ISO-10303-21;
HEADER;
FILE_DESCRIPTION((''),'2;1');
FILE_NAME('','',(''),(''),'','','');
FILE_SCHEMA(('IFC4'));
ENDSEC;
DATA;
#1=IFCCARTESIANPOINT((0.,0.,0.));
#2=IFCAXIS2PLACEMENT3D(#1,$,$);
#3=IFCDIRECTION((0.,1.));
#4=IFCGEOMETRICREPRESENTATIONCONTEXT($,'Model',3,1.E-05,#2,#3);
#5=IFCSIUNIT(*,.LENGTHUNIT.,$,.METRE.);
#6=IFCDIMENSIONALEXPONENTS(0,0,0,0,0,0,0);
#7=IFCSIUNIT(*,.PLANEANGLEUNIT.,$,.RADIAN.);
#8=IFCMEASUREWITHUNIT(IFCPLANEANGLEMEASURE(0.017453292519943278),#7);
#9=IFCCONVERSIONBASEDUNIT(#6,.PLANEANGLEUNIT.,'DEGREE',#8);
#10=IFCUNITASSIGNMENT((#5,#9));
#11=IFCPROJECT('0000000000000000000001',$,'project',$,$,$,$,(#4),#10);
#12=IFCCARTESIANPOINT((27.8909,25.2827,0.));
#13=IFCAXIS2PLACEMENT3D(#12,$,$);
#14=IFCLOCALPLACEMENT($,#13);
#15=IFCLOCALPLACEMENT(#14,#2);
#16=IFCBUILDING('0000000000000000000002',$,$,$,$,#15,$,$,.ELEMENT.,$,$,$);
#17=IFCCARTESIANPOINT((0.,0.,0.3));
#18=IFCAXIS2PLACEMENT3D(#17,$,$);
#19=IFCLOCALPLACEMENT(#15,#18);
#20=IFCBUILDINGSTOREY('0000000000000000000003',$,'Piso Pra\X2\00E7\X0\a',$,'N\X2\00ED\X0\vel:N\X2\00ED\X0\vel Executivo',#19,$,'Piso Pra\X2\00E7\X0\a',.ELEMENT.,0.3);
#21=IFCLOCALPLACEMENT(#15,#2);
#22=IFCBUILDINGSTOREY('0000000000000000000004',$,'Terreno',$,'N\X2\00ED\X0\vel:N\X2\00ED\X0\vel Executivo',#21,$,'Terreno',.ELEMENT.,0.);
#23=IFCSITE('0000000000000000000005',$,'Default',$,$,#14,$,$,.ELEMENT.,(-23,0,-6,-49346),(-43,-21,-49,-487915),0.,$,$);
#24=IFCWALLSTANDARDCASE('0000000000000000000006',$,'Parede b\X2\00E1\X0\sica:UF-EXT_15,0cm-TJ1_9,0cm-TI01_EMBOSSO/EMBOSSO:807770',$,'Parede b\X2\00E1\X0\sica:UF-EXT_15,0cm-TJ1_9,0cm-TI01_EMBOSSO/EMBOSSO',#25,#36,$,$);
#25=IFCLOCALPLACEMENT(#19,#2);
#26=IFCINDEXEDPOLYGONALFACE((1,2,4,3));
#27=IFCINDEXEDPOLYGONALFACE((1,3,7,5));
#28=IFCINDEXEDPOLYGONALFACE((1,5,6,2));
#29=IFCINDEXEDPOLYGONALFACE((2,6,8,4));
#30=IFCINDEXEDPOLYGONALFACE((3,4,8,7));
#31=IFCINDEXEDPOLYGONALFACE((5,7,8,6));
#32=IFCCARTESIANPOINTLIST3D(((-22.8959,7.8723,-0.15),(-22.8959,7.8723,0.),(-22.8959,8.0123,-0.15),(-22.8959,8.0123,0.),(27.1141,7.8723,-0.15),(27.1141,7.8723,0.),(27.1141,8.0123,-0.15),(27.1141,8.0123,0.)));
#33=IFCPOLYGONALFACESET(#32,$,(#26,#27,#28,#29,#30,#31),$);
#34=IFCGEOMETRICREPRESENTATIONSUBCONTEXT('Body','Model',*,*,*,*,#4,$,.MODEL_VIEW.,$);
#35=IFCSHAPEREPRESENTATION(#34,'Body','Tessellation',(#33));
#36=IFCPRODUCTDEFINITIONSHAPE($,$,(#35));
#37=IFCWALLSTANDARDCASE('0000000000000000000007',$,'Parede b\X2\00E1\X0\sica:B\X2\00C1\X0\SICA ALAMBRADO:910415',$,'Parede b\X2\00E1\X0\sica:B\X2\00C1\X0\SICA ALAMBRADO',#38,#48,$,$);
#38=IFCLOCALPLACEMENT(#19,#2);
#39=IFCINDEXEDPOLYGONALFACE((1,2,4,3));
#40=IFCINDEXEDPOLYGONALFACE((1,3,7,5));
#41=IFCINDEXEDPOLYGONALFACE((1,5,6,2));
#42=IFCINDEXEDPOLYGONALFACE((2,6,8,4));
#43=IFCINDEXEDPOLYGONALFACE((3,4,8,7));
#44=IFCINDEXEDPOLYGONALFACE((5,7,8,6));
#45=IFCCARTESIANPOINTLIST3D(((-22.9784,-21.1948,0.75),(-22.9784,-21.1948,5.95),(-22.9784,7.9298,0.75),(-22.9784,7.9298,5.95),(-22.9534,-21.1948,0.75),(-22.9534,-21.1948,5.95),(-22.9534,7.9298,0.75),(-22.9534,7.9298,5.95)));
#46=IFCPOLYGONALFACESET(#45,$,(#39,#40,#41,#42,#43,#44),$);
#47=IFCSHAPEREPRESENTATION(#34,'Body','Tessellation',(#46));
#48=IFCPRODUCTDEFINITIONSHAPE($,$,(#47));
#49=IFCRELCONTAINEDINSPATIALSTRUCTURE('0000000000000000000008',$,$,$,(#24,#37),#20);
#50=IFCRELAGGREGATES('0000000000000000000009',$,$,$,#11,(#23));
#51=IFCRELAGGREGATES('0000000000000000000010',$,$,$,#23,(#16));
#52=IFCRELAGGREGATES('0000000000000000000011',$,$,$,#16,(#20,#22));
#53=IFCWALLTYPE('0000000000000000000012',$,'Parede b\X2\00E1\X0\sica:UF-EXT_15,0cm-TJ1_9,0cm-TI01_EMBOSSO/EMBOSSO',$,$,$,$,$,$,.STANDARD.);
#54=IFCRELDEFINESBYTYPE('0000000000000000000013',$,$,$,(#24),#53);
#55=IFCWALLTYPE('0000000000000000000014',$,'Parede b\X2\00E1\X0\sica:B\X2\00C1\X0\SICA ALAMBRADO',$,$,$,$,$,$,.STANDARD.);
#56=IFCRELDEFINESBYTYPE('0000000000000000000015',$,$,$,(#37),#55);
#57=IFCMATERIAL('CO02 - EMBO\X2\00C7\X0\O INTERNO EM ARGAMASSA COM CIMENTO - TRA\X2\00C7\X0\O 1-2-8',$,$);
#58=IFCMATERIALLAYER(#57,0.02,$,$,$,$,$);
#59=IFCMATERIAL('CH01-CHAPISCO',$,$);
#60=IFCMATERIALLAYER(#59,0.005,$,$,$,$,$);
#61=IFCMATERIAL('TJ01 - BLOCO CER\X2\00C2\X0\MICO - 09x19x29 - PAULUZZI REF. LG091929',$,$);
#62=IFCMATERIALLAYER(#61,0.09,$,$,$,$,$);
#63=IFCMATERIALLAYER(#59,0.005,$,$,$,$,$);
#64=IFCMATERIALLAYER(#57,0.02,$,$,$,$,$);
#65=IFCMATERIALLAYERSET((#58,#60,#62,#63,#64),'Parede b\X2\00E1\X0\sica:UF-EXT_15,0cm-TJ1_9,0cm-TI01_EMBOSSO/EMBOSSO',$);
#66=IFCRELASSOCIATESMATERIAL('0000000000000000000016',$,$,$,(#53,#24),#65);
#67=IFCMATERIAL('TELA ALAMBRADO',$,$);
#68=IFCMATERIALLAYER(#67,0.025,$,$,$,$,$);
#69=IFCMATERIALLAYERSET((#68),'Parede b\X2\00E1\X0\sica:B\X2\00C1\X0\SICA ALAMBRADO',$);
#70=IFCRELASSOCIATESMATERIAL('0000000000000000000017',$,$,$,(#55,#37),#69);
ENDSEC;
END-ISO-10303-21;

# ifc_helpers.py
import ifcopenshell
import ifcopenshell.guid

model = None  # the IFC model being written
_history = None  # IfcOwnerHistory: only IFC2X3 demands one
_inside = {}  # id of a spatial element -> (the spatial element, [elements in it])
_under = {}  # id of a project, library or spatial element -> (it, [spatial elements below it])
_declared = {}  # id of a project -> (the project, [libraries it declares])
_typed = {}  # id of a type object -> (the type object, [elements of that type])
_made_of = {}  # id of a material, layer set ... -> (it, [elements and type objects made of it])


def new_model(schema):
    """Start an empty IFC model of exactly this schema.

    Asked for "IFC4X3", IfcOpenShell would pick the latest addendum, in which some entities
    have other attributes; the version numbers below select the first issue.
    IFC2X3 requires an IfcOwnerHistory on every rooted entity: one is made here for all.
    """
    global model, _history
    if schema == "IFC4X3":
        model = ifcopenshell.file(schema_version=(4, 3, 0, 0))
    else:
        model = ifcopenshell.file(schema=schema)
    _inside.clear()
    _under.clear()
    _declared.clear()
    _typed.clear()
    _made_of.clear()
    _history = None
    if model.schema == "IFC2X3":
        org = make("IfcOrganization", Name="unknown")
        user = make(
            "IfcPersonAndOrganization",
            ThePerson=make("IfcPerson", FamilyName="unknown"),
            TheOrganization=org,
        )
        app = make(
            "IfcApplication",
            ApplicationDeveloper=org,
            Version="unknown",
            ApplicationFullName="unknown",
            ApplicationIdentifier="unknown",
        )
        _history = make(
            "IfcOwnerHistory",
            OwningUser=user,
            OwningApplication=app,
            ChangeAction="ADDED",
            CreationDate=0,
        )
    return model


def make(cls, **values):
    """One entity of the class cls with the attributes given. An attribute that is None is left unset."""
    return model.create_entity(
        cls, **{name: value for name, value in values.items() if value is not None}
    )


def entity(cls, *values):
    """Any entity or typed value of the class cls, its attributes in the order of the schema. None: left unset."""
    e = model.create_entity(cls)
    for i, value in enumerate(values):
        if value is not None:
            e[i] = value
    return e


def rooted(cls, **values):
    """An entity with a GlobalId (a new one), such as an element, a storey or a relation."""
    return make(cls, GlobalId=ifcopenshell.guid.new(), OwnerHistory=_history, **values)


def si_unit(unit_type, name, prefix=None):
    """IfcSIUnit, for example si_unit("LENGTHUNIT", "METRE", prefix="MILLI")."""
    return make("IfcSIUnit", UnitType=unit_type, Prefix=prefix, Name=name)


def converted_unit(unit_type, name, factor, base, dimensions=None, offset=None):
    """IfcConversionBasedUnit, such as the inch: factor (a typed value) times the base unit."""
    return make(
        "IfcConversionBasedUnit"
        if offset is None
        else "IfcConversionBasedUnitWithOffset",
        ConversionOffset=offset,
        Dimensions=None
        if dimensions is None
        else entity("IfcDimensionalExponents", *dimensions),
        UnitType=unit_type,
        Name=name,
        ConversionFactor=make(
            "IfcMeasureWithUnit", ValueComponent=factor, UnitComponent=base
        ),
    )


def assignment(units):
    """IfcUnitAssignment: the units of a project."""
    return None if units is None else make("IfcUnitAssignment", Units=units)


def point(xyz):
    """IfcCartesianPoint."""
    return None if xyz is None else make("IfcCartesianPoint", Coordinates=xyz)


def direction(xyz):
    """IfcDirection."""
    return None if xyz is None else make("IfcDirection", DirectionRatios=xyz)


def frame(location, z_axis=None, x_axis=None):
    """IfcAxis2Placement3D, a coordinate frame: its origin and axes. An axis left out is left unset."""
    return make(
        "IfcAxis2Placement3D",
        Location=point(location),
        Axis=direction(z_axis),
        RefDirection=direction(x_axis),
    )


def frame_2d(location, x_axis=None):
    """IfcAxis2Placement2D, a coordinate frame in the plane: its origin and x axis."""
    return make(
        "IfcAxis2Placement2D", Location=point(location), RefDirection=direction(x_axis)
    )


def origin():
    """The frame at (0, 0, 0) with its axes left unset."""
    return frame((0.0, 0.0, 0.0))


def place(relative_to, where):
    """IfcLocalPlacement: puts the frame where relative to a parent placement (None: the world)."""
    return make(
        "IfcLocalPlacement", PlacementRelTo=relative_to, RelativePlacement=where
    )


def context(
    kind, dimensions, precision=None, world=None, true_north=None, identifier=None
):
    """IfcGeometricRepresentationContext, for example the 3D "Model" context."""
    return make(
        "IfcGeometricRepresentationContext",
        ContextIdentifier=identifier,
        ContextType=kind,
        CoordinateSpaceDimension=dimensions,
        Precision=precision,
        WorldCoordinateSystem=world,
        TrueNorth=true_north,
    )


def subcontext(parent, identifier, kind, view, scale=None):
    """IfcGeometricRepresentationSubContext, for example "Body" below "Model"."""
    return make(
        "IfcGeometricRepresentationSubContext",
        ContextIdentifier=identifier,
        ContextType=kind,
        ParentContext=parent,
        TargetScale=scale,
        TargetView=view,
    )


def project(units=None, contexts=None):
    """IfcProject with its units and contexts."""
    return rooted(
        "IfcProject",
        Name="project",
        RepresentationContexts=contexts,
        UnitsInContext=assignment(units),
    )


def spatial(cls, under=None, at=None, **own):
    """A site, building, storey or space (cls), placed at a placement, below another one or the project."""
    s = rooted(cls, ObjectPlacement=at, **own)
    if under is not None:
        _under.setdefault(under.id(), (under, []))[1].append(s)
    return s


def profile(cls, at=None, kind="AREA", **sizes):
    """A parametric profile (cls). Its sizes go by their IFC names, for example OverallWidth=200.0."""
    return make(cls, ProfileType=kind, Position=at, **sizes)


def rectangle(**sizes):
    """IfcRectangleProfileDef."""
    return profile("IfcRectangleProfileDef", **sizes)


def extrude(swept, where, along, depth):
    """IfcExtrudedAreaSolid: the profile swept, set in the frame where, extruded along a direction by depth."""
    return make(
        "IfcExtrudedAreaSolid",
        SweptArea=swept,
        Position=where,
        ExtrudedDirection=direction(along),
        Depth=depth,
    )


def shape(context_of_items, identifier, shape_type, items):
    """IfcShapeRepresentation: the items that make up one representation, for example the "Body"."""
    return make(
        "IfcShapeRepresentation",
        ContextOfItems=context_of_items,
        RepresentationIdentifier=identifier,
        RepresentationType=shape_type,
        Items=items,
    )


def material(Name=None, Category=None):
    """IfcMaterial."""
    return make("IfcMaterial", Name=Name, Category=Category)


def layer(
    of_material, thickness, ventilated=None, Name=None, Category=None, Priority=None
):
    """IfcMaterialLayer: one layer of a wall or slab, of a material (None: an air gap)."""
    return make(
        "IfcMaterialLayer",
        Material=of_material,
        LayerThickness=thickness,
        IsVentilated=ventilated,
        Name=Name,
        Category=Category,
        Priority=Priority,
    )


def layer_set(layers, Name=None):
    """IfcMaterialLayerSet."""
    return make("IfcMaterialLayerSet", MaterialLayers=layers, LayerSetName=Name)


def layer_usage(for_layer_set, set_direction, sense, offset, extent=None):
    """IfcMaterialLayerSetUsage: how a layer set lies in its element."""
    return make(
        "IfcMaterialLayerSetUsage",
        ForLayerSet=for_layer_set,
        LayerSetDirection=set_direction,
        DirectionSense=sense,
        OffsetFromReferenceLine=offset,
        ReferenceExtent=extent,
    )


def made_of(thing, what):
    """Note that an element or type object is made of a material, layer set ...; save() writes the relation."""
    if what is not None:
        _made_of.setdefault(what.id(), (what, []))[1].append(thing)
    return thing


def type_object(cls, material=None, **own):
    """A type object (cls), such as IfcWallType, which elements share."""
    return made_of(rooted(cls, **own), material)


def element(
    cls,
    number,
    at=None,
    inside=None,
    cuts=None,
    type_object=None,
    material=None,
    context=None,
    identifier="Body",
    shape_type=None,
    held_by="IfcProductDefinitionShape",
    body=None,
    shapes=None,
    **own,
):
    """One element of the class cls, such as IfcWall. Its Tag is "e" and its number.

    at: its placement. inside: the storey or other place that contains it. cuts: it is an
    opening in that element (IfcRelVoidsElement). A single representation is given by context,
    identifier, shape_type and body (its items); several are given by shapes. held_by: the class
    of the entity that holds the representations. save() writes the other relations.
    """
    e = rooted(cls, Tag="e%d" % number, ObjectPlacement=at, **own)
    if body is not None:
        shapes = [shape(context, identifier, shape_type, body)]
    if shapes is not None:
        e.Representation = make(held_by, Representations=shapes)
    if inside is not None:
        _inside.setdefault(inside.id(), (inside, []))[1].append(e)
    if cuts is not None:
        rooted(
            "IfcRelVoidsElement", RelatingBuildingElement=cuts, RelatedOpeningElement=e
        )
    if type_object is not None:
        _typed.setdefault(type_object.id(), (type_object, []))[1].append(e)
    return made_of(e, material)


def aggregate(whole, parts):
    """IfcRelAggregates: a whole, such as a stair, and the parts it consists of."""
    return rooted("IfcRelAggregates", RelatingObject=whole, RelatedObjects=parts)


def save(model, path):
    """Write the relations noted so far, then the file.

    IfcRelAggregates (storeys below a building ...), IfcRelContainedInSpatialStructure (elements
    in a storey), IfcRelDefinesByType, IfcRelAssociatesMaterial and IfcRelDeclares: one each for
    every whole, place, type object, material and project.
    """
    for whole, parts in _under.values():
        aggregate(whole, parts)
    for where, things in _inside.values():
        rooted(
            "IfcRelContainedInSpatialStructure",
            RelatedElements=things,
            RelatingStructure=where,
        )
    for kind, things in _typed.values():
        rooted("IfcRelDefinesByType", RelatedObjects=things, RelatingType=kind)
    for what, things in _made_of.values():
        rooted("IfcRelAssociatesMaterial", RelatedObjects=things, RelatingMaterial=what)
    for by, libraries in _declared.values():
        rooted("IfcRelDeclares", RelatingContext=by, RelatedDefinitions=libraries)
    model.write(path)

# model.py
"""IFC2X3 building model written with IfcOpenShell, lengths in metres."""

from ifc_helpers import new_model, entity, si_unit, converted_unit, direction, frame, frame_2d, origin, place, context, subcontext, project, spatial, rectangle, extrude, material, layer, layer_set, layer_usage, type_object, element, save


model = new_model("IFC2X3")

# Units and contexts
model_context = context("Model", 3, precision=1e-05, world=origin(), true_north=direction((0.0, 1.0)))
body_context = subcontext(model_context, "Body", "Model", "MODEL_VIEW")
ifc_project = project(units=[si_unit("LENGTHUNIT", "METRE"), converted_unit("PLANEANGLEUNIT", "DEGREE", entity("IfcPlaneAngleMeasure", 0.017453292519943278), si_unit("PLANEANGLEUNIT", "RADIAN"), dimensions=[0, 0, 0, 0, 0, 0, 0])], contexts=[model_context])

# Site, building, storey
site_placement = place(None, frame((27.8909, 25.2827, 0.0)))
site = spatial("IfcSite", under=ifc_project, at=site_placement, Name="Default", CompositionType="ELEMENT", RefLatitude=(-23, 0, -6, -49346), RefLongitude=(-43, -21, -49, -487915), RefElevation=0.0)
building_placement = place(site_placement, origin())
building = spatial("IfcBuilding", under=site, at=building_placement, CompositionType="ELEMENT")
storey_1_placement = place(building_placement, frame((0.0, 0.0, 0.3)))
storey_1 = spatial("IfcBuildingStorey", under=building, at=storey_1_placement, Name="Piso Praça", ObjectType="Nível:Nível Executivo", LongName="Piso Praça", CompositionType="ELEMENT", Elevation=0.3)

# Wall
ifc_material_1 = material(Name="CO02 - EMBOÇO INTERNO EM ARGAMASSA COM CIMENTO - TRAÇO 1-2-8")
ifc_layer_1 = layer(ifc_material_1, 0.02)
ifc_material_2 = material(Name="CH01-CHAPISCO")
ifc_layer_2 = layer(ifc_material_2, 0.005)
ifc_material_3 = material(Name="TJ01 - BLOCO CERÂMICO - 09x19x29 - PAULUZZI REF. LG091929")
ifc_layer_3 = layer(ifc_material_3, 0.09)
ifc_layer_4 = layer(ifc_material_2, 0.005)
ifc_layer_5 = layer(ifc_material_1, 0.02)
ifc_layer_set_1 = layer_set([ifc_layer_1, ifc_layer_2, ifc_layer_3, ifc_layer_4, ifc_layer_5], Name="Parede básica:UF-EXT_15,0cm-TJ1_9,0cm-TI01_EMBOSSO/EMBOSSO")
ifc_layer_usage_1 = layer_usage(ifc_layer_set_1, "AXIS2", "NEGATIVE", 0.07)
wall_type_1 = type_object("IfcWallType", Name="Parede básica:UF-EXT_15,0cm-TJ1_9,0cm-TI01_EMBOSSO/EMBOSSO", PredefinedType="STANDARD", material=ifc_layer_set_1)
wall_1_placement = place(storey_1_placement, frame((-22.8959, 7.9423, -0.15)))
element("IfcWallStandardCase", 1, at=wall_1_placement, inside=storey_1, type_object=wall_type_1, material=ifc_layer_usage_1, Name="Parede básica:UF-EXT_15,0cm-TJ1_9,0cm-TI01_EMBOSSO/EMBOSSO:807770", ObjectType="Parede básica:UF-EXT_15,0cm-TJ1_9,0cm-TI01_EMBOSSO/EMBOSSO", context=body_context, shape_type="SweptSolid", body=[
    extrude(rectangle(XDim=50.01, YDim=0.14, at=frame_2d((25.005, 0.0), x_axis=(-1.0, 0.0))), origin(), (0.0, 0.0, 1.0), 0.15),
])

# Shared definitions
ifc_material_4 = material(Name="TELA ALAMBRADO")
ifc_layer_6 = layer(ifc_material_4, 0.025)
ifc_layer_set_2 = layer_set([ifc_layer_6], Name="Parede básica:BÁSICA ALAMBRADO")
wall_type_2 = type_object("IfcWallType", Name="Parede básica:BÁSICA ALAMBRADO", PredefinedType="STANDARD", material=ifc_layer_set_2)

# Wall
ifc_layer_usage_2 = layer_usage(ifc_layer_set_2, "AXIS2", "POSITIVE", -0.0125)
wall_2_placement = place(storey_1_placement, frame((-22.9659, 7.9298, 0.75), z_axis=(0.0, 0.0, 1.0), x_axis=(0.0, -1.0, 0.0)))
element("IfcWallStandardCase", 2, at=wall_2_placement, inside=storey_1, type_object=wall_type_2, material=ifc_layer_usage_2, Name="Parede básica:BÁSICA ALAMBRADO:910415", ObjectType="Parede básica:BÁSICA ALAMBRADO", context=body_context, shape_type="SweptSolid", body=[
    extrude(rectangle(XDim=29.1246, YDim=0.025, at=frame_2d((14.5623, 0.0), x_axis=(-1.0, 0.0))), origin(), (0.0, 0.0, 1.0), 5.2),
])

# Shared definitions
storey_2_placement = place(building_placement, origin())
storey_2 = spatial("IfcBuildingStorey", under=building, at=storey_2_placement, Name="Terreno", ObjectType="Nível:Nível Executivo", LongName="Terreno", CompositionType="ELEMENT", Elevation=0.0)

save(model, "model.ifc")
